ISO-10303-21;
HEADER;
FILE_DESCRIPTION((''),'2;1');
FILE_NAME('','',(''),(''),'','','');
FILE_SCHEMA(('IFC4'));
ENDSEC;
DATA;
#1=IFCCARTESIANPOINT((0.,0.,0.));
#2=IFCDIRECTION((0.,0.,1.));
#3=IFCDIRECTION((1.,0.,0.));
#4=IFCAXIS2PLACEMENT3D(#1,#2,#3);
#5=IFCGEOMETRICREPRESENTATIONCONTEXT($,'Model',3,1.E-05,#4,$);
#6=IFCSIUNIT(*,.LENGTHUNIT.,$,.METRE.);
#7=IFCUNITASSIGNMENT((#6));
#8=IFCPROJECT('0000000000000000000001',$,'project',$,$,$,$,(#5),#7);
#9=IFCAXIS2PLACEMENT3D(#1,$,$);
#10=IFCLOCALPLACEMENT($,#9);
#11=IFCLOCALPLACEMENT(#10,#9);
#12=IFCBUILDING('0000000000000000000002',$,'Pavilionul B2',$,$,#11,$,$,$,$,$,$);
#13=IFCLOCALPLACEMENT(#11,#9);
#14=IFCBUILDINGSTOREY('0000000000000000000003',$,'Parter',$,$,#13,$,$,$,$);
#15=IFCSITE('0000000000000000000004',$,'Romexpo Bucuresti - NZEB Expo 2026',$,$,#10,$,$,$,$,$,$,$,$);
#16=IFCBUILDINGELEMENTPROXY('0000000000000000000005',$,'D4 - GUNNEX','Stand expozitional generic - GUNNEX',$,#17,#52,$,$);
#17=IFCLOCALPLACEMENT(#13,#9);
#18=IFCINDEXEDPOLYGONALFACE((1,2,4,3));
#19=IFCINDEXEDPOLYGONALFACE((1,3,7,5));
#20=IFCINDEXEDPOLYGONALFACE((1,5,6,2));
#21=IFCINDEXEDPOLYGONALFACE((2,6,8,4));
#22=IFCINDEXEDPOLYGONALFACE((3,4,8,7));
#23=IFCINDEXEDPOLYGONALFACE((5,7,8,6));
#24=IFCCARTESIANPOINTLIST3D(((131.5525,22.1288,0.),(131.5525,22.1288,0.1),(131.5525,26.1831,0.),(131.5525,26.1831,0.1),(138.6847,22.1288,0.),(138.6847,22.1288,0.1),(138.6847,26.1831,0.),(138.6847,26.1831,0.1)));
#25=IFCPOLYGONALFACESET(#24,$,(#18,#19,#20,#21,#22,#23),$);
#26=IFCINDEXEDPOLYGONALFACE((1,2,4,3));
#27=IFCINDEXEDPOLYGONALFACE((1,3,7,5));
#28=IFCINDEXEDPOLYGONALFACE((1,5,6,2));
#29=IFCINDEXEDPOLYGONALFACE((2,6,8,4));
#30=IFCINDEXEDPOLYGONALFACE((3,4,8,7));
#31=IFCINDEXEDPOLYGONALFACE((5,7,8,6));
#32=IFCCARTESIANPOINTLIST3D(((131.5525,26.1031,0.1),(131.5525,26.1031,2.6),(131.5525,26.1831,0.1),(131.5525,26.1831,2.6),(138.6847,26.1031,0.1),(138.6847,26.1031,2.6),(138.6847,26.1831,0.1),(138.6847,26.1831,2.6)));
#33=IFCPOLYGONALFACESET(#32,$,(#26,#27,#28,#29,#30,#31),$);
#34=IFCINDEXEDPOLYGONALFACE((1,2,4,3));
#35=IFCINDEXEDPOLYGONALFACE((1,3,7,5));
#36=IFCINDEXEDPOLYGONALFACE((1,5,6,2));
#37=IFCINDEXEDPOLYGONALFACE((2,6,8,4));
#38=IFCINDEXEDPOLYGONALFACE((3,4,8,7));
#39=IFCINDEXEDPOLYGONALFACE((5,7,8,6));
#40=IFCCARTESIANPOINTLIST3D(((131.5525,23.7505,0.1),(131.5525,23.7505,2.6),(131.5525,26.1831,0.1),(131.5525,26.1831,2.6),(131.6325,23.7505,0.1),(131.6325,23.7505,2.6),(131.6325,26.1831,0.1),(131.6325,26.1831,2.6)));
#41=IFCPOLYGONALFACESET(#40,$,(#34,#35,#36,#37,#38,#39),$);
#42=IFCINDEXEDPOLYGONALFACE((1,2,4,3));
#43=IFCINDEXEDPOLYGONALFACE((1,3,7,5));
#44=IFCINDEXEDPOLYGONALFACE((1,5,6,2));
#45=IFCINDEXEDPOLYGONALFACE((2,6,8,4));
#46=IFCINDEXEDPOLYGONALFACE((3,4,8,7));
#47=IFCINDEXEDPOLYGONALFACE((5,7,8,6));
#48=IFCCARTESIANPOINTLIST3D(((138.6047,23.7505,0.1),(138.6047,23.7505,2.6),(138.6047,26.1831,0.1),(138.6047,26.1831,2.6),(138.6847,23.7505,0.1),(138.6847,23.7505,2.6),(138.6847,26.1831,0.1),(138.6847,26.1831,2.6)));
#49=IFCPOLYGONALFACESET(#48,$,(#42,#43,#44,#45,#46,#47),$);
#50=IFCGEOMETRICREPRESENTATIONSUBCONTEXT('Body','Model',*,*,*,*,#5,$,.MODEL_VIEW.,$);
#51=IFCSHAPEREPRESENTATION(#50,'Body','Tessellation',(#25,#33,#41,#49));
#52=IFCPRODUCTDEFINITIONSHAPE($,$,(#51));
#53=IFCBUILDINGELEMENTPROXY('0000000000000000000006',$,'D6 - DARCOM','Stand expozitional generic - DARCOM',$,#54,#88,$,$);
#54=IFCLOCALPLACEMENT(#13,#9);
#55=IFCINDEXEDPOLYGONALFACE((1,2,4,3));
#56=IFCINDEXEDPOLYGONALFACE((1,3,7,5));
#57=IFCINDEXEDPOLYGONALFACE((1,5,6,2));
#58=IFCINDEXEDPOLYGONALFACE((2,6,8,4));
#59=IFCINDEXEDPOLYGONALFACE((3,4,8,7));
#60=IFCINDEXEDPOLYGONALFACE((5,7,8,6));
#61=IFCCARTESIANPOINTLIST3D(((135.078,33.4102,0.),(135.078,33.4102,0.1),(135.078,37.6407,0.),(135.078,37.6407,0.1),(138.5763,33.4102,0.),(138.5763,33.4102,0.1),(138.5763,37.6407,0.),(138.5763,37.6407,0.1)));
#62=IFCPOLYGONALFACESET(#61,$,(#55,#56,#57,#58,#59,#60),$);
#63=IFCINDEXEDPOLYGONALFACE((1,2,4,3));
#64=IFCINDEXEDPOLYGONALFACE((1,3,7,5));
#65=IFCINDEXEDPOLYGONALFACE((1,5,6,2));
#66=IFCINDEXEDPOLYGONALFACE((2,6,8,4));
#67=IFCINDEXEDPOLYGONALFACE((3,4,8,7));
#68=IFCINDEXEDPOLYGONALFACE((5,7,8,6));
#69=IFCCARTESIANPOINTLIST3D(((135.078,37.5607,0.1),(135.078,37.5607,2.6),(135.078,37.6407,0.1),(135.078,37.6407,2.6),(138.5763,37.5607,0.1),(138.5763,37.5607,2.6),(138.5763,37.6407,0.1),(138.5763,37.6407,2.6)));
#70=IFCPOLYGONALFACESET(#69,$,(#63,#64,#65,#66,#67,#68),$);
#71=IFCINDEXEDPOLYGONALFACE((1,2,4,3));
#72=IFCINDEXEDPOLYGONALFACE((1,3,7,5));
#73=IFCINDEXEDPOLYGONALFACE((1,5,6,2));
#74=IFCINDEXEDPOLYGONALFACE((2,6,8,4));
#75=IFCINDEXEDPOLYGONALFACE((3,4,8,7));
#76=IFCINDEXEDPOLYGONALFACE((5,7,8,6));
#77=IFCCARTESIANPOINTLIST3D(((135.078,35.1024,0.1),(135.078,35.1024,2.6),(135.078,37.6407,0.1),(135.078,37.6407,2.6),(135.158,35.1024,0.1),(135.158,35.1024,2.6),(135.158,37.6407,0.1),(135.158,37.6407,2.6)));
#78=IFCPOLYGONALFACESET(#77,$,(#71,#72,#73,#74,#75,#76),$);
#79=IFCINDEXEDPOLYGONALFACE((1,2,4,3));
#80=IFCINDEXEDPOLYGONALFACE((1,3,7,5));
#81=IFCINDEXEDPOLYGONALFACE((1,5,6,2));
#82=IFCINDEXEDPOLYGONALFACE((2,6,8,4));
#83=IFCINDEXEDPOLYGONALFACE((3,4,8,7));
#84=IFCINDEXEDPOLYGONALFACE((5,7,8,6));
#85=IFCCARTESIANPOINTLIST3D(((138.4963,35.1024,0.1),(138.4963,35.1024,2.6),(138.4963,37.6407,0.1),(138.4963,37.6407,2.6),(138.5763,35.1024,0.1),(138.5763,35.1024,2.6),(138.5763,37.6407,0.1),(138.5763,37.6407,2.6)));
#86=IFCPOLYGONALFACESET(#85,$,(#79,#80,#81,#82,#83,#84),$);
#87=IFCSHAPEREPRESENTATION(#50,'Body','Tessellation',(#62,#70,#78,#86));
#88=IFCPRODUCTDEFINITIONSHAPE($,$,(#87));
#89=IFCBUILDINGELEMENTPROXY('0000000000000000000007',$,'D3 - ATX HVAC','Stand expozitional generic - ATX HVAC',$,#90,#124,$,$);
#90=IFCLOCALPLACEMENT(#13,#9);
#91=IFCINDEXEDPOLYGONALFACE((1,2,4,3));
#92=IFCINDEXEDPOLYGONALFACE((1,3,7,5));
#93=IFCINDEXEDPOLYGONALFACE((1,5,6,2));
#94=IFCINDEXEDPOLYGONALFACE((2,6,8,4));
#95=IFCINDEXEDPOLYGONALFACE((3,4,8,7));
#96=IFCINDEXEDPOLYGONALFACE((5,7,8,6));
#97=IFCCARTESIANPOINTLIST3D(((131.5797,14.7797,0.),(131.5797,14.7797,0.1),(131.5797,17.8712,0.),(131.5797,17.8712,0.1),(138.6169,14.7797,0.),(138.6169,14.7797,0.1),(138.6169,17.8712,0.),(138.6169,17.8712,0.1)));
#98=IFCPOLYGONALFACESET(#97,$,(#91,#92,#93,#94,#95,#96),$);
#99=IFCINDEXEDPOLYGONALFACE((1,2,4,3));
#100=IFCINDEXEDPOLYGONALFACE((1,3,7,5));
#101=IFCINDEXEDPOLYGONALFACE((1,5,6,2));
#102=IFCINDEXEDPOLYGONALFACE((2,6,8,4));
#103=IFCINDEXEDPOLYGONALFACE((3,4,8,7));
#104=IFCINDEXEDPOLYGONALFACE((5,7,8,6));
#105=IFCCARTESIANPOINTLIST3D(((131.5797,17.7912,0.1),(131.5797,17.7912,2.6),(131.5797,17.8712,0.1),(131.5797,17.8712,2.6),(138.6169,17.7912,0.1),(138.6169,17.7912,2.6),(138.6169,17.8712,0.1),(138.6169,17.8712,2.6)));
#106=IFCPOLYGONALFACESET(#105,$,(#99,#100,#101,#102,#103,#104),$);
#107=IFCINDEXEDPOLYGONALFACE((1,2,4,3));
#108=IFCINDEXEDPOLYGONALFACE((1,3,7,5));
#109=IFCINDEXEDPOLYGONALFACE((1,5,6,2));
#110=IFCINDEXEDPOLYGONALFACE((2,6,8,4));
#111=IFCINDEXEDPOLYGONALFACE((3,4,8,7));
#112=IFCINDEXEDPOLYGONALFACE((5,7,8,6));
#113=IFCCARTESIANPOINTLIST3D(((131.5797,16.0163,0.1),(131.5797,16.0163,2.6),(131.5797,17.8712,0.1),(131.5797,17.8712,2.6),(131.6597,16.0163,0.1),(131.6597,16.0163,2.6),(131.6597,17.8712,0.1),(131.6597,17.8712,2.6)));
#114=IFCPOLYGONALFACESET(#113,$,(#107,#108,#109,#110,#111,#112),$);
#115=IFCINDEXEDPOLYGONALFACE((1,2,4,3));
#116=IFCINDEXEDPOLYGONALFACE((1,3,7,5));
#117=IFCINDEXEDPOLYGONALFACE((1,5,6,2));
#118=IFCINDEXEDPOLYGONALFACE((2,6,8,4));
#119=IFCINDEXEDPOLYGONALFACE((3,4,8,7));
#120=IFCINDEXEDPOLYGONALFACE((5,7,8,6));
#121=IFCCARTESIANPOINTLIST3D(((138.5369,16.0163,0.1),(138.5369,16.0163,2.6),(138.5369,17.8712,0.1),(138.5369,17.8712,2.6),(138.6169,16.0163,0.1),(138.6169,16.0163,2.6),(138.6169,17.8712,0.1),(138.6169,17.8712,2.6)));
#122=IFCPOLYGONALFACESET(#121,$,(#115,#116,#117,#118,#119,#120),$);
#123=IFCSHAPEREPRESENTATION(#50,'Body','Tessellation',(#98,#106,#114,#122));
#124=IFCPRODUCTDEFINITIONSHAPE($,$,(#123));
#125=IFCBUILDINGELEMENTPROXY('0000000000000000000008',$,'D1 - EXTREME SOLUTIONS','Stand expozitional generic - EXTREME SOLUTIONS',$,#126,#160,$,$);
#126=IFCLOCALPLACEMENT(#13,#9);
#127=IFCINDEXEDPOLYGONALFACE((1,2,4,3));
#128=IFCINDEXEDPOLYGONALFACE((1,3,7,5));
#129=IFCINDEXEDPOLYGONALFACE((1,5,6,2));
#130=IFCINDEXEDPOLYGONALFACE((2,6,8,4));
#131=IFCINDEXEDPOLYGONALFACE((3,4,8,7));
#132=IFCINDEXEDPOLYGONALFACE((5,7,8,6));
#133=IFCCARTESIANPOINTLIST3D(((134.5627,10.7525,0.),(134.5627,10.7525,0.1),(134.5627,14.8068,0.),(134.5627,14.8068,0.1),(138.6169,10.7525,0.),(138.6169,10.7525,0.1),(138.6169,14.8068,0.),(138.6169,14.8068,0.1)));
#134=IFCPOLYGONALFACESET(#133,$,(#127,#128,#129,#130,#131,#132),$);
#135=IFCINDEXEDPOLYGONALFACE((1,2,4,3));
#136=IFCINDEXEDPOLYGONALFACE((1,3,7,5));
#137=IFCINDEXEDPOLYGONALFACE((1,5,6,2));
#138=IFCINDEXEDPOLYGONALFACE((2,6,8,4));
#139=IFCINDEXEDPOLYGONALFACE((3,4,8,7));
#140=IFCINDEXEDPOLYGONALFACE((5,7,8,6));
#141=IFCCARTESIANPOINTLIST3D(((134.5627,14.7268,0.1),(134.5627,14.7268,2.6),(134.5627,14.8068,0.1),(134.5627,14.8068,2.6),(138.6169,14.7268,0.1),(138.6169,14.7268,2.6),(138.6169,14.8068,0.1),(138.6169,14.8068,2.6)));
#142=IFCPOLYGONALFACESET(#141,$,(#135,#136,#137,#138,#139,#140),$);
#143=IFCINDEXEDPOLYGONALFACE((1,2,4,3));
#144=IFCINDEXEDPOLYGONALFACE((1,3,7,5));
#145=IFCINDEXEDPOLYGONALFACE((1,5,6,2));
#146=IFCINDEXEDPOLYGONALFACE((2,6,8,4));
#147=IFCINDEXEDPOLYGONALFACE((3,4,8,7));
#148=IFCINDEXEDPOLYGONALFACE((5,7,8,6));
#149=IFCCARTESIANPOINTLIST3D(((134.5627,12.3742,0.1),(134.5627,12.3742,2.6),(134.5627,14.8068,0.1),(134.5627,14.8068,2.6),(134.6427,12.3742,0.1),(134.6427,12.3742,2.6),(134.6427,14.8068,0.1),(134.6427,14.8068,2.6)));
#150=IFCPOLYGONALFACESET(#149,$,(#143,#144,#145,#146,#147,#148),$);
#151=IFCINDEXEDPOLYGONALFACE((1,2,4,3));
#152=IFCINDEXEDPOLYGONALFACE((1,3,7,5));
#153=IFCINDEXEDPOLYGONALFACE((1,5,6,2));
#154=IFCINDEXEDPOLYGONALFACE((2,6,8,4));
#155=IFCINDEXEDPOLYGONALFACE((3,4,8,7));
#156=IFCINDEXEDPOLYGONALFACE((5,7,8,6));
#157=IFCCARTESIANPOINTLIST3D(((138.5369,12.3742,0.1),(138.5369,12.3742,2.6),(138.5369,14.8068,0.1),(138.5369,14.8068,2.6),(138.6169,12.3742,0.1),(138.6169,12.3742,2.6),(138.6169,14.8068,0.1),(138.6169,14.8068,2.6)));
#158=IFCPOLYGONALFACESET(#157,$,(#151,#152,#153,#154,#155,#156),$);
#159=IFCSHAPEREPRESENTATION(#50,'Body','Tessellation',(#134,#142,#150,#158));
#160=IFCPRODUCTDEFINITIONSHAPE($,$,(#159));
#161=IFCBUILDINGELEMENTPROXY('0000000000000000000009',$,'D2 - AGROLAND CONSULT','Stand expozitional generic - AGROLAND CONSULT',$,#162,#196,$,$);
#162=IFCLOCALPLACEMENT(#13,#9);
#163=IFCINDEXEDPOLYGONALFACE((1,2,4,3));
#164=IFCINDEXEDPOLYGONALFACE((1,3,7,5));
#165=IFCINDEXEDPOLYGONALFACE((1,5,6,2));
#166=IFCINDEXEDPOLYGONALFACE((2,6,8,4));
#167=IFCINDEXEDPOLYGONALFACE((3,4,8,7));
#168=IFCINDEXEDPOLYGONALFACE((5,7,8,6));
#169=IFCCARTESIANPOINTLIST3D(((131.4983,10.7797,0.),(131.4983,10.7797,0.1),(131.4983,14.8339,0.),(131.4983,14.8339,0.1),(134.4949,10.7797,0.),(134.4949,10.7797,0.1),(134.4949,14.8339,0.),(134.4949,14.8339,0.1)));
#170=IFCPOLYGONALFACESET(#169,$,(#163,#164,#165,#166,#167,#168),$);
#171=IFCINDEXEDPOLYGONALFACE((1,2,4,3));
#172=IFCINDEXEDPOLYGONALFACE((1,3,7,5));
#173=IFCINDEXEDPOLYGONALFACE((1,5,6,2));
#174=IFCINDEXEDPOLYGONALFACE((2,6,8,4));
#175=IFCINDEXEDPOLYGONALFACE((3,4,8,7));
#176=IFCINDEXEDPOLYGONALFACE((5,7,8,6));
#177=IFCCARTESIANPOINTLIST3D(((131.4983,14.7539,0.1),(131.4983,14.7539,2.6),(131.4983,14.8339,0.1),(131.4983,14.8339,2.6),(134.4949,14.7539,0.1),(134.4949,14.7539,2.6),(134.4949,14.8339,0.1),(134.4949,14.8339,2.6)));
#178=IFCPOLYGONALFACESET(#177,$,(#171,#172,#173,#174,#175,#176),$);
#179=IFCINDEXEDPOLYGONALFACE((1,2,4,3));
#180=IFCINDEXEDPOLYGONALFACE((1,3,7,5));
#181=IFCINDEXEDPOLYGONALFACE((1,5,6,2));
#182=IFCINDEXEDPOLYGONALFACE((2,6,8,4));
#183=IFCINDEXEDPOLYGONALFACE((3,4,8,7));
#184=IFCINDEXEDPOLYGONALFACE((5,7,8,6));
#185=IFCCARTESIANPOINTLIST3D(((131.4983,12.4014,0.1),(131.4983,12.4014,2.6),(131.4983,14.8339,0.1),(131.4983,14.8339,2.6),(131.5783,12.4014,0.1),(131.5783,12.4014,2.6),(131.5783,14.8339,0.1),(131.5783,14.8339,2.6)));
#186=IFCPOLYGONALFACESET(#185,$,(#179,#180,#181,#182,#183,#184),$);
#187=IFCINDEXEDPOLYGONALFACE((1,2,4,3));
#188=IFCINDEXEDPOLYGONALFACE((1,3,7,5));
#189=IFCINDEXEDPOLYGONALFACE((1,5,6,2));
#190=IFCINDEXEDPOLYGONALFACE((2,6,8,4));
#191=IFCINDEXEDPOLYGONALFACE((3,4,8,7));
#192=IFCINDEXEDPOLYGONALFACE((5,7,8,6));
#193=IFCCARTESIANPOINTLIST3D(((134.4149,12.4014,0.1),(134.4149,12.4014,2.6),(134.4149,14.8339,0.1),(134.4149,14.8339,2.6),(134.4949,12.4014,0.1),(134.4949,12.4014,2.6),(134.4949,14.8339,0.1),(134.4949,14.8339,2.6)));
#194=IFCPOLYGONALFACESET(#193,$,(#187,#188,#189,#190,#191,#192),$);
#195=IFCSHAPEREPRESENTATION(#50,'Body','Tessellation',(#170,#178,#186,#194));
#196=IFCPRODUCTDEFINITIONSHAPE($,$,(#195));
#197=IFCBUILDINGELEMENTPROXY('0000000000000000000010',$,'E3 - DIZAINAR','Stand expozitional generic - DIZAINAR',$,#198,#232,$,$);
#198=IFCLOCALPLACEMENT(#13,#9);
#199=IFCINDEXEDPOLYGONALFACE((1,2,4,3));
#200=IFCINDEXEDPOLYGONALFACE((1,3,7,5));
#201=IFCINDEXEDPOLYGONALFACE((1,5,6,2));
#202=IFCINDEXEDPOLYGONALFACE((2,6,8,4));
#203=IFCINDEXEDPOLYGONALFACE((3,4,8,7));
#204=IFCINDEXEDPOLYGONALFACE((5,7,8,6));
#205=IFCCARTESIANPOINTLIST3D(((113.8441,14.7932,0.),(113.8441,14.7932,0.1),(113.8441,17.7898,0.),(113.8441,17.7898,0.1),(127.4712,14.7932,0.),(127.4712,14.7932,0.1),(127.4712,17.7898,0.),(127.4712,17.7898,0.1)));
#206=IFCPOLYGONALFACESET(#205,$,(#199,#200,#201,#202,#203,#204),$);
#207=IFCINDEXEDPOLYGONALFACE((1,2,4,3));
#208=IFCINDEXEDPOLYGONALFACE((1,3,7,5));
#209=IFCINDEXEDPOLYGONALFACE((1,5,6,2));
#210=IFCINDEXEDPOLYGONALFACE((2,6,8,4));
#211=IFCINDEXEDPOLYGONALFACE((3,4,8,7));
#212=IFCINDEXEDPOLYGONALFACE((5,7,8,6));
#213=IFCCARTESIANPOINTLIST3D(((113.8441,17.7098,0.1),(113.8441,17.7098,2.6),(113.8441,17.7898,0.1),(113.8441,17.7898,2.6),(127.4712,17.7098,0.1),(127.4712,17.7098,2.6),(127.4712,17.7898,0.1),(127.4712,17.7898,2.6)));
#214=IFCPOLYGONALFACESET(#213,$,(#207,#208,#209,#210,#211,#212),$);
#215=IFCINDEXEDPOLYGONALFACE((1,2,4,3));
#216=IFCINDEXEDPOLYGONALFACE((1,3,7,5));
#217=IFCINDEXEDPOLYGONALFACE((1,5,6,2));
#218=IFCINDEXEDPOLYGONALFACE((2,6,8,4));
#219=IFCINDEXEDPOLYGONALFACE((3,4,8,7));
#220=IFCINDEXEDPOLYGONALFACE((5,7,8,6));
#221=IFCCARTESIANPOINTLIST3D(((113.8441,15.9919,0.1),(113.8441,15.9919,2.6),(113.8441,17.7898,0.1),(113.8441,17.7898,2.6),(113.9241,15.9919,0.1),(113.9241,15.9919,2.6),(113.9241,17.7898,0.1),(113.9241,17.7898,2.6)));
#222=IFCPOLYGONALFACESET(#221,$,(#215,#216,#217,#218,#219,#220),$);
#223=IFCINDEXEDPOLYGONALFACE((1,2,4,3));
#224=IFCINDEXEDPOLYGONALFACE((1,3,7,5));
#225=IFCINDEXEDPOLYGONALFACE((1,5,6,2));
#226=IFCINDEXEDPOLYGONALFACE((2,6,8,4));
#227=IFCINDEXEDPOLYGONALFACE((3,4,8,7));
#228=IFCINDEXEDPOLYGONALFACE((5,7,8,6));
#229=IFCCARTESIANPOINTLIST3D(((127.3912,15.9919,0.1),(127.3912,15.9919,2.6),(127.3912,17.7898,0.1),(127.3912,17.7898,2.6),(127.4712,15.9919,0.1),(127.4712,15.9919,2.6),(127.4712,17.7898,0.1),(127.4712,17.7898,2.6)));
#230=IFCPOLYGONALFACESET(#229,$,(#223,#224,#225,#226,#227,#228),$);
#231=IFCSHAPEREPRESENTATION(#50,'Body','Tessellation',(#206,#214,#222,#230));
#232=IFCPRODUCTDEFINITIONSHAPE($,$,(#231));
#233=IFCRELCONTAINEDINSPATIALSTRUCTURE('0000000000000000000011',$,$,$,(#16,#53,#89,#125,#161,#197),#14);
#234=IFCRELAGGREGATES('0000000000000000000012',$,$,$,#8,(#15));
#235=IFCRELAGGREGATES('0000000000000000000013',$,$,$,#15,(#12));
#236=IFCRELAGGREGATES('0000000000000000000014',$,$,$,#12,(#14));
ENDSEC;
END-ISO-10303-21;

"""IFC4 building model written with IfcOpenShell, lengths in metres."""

from ifc_helpers import new_model, si_unit, frame, frame_2d, origin, origin_with_axes, place, context, subcontext, project, spatial, rectangle, extrude, element, save


model = new_model("IFC4")

# Units and contexts
model_context = context("Model", 3, precision=1e-05, world=origin_with_axes())
body_context = subcontext(model_context, "Body", "Model", "MODEL_VIEW")
ifc_project = project(units=[si_unit("LENGTHUNIT", "METRE")], contexts=[model_context])

# Site, building, storey
site_placement = place(None, origin())
site = spatial("IfcSite", under=ifc_project, at=site_placement, Name="Romexpo Bucuresti - NZEB Expo 2026")
building_placement = place(site_placement, origin())
building = spatial("IfcBuilding", under=site, at=building_placement, Name="Pavilionul B2")
storey_placement = place(building_placement, origin())
storey = spatial("IfcBuildingStorey", under=building, at=storey_placement, Name="Parter")

# Building element proxies
proxy_1_placement = place(storey_placement, frame((131.5525, 22.1288, 0.0), z_axis=(0.0, 0.0, 1.0), x_axis=(1.0, 0.0, 0.0)))
element("IfcBuildingElementProxy", 1, at=proxy_1_placement, inside=storey, Name="D4 - GUNNEX", Description="Stand expozitional generic - GUNNEX", context=body_context, shape_type="SweptSolid", body=[
    extrude(rectangle(XDim=7.1322, YDim=4.0542, at=frame_2d((3.5661, 2.0271))), origin(), (0.0, 0.0, 1.0), 0.1),
    extrude(rectangle(XDim=7.1322, YDim=0.08, at=frame_2d((3.5661, 4.0142))), frame((0.0, 0.0, 0.1)), (0.0, 0.0, 1.0), 2.5),
    extrude(rectangle(XDim=0.08, YDim=2.4325, at=frame_2d((0.04, 2.838))), frame((0.0, 0.0, 0.1)), (0.0, 0.0, 1.0), 2.5),
    extrude(rectangle(XDim=0.08, YDim=2.4325, at=frame_2d((7.0922, 2.838))), frame((0.0, 0.0, 0.1)), (0.0, 0.0, 1.0), 2.5),
])
proxy_2_placement = place(storey_placement, frame((135.078, 33.4102, 0.0), z_axis=(0.0, 0.0, 1.0), x_axis=(1.0, 0.0, 0.0)))
element("IfcBuildingElementProxy", 2, at=proxy_2_placement, inside=storey, Name="D6 - DARCOM", Description="Stand expozitional generic - DARCOM", context=body_context, shape_type="SweptSolid", body=[
    extrude(rectangle(XDim=3.4983, YDim=4.2305, at=frame_2d((1.7492, 2.1153))), origin(), (0.0, 0.0, 1.0), 0.1),
    extrude(rectangle(XDim=3.4983, YDim=0.08, at=frame_2d((1.7492, 4.1905))), frame((0.0, 0.0, 0.1)), (0.0, 0.0, 1.0), 2.5),
    extrude(rectangle(XDim=0.08, YDim=2.5383, at=frame_2d((0.04, 2.9614))), frame((0.0, 0.0, 0.1)), (0.0, 0.0, 1.0), 2.5),
    extrude(rectangle(XDim=0.08, YDim=2.5383, at=frame_2d((3.4583, 2.9614))), frame((0.0, 0.0, 0.1)), (0.0, 0.0, 1.0), 2.5),
])
proxy_3_placement = place(storey_placement, frame((131.5797, 14.7797, 0.0), z_axis=(0.0, 0.0, 1.0), x_axis=(1.0, 0.0, 0.0)))
element("IfcBuildingElementProxy", 3, at=proxy_3_placement, inside=storey, Name="D3 - ATX HVAC", Description="Stand expozitional generic - ATX HVAC", context=body_context, shape_type="SweptSolid", body=[
    extrude(rectangle(XDim=7.0373, YDim=3.0915, at=frame_2d((3.5186, 1.5458))), origin(), (0.0, 0.0, 1.0), 0.1),
    extrude(rectangle(XDim=7.0373, YDim=0.08, at=frame_2d((3.5186, 3.0515))), frame((0.0, 0.0, 0.1)), (0.0, 0.0, 1.0), 2.5),
    extrude(rectangle(XDim=0.08, YDim=1.8549, at=frame_2d((0.04, 2.1641))), frame((0.0, 0.0, 0.1)), (0.0, 0.0, 1.0), 2.5),
    extrude(rectangle(XDim=0.08, YDim=1.8549, at=frame_2d((6.9973, 2.1641))), frame((0.0, 0.0, 0.1)), (0.0, 0.0, 1.0), 2.5),
])
proxy_4_placement = place(storey_placement, frame((134.5627, 10.7525, 0.0), z_axis=(0.0, 0.0, 1.0), x_axis=(1.0, 0.0, 0.0)))
element("IfcBuildingElementProxy", 4, at=proxy_4_placement, inside=storey, Name="D1 - EXTREME SOLUTIONS", Description="Stand expozitional generic - EXTREME SOLUTIONS", context=body_context, shape_type="SweptSolid", body=[
    extrude(rectangle(XDim=4.0542, YDim=4.0542, at=frame_2d((2.0271, 2.0271))), origin(), (0.0, 0.0, 1.0), 0.1),
    extrude(rectangle(XDim=4.0542, YDim=0.08, at=frame_2d((2.0271, 4.0142))), frame((0.0, 0.0, 0.1)), (0.0, 0.0, 1.0), 2.5),
    extrude(rectangle(XDim=0.08, YDim=2.4325, at=frame_2d((0.04, 2.838))), frame((0.0, 0.0, 0.1)), (0.0, 0.0, 1.0), 2.5),
    extrude(rectangle(XDim=0.08, YDim=2.4325, at=frame_2d((4.0142, 2.838))), frame((0.0, 0.0, 0.1)), (0.0, 0.0, 1.0), 2.5),
])
proxy_5_placement = place(storey_placement, frame((131.4983, 10.7797, 0.0), z_axis=(0.0, 0.0, 1.0), x_axis=(1.0, 0.0, 0.0)))
element("IfcBuildingElementProxy", 5, at=proxy_5_placement, inside=storey, Name="D2 - AGROLAND CONSULT", Description="Stand expozitional generic - AGROLAND CONSULT", context=body_context, shape_type="SweptSolid", body=[
    extrude(rectangle(XDim=2.9966, YDim=4.0542, at=frame_2d((1.4983, 2.0271))), origin(), (0.0, 0.0, 1.0), 0.1),
    extrude(rectangle(XDim=2.9966, YDim=0.08, at=frame_2d((1.4983, 4.0142))), frame((0.0, 0.0, 0.1)), (0.0, 0.0, 1.0), 2.5),
    extrude(rectangle(XDim=0.08, YDim=2.4325, at=frame_2d((0.04, 2.838))), frame((0.0, 0.0, 0.1)), (0.0, 0.0, 1.0), 2.5),
    extrude(rectangle(XDim=0.08, YDim=2.4325, at=frame_2d((2.9566, 2.838))), frame((0.0, 0.0, 0.1)), (0.0, 0.0, 1.0), 2.5),
])
proxy_6_placement = place(storey_placement, frame((113.8441, 14.7932, 0.0), z_axis=(0.0, 0.0, 1.0), x_axis=(1.0, 0.0, 0.0)))
element("IfcBuildingElementProxy", 6, at=proxy_6_placement, inside=storey, Name="E3 - DIZAINAR", Description="Stand expozitional generic - DIZAINAR", context=body_context, shape_type="SweptSolid", body=[
    extrude(rectangle(XDim=13.6271, YDim=2.9966, at=frame_2d((6.8136, 1.4983))), origin(), (0.0, 0.0, 1.0), 0.1),
    extrude(rectangle(XDim=13.6271, YDim=0.08, at=frame_2d((6.8136, 2.9566))), frame((0.0, 0.0, 0.1)), (0.0, 0.0, 1.0), 2.5),
    extrude(rectangle(XDim=0.08, YDim=1.798, at=frame_2d((0.04, 2.0976))), frame((0.0, 0.0, 0.1)), (0.0, 0.0, 1.0), 2.5),
    extrude(rectangle(XDim=0.08, YDim=1.798, at=frame_2d((13.5871, 2.0976))), frame((0.0, 0.0, 0.1)), (0.0, 0.0, 1.0), 2.5),
])

save(model, "model.ifc")
